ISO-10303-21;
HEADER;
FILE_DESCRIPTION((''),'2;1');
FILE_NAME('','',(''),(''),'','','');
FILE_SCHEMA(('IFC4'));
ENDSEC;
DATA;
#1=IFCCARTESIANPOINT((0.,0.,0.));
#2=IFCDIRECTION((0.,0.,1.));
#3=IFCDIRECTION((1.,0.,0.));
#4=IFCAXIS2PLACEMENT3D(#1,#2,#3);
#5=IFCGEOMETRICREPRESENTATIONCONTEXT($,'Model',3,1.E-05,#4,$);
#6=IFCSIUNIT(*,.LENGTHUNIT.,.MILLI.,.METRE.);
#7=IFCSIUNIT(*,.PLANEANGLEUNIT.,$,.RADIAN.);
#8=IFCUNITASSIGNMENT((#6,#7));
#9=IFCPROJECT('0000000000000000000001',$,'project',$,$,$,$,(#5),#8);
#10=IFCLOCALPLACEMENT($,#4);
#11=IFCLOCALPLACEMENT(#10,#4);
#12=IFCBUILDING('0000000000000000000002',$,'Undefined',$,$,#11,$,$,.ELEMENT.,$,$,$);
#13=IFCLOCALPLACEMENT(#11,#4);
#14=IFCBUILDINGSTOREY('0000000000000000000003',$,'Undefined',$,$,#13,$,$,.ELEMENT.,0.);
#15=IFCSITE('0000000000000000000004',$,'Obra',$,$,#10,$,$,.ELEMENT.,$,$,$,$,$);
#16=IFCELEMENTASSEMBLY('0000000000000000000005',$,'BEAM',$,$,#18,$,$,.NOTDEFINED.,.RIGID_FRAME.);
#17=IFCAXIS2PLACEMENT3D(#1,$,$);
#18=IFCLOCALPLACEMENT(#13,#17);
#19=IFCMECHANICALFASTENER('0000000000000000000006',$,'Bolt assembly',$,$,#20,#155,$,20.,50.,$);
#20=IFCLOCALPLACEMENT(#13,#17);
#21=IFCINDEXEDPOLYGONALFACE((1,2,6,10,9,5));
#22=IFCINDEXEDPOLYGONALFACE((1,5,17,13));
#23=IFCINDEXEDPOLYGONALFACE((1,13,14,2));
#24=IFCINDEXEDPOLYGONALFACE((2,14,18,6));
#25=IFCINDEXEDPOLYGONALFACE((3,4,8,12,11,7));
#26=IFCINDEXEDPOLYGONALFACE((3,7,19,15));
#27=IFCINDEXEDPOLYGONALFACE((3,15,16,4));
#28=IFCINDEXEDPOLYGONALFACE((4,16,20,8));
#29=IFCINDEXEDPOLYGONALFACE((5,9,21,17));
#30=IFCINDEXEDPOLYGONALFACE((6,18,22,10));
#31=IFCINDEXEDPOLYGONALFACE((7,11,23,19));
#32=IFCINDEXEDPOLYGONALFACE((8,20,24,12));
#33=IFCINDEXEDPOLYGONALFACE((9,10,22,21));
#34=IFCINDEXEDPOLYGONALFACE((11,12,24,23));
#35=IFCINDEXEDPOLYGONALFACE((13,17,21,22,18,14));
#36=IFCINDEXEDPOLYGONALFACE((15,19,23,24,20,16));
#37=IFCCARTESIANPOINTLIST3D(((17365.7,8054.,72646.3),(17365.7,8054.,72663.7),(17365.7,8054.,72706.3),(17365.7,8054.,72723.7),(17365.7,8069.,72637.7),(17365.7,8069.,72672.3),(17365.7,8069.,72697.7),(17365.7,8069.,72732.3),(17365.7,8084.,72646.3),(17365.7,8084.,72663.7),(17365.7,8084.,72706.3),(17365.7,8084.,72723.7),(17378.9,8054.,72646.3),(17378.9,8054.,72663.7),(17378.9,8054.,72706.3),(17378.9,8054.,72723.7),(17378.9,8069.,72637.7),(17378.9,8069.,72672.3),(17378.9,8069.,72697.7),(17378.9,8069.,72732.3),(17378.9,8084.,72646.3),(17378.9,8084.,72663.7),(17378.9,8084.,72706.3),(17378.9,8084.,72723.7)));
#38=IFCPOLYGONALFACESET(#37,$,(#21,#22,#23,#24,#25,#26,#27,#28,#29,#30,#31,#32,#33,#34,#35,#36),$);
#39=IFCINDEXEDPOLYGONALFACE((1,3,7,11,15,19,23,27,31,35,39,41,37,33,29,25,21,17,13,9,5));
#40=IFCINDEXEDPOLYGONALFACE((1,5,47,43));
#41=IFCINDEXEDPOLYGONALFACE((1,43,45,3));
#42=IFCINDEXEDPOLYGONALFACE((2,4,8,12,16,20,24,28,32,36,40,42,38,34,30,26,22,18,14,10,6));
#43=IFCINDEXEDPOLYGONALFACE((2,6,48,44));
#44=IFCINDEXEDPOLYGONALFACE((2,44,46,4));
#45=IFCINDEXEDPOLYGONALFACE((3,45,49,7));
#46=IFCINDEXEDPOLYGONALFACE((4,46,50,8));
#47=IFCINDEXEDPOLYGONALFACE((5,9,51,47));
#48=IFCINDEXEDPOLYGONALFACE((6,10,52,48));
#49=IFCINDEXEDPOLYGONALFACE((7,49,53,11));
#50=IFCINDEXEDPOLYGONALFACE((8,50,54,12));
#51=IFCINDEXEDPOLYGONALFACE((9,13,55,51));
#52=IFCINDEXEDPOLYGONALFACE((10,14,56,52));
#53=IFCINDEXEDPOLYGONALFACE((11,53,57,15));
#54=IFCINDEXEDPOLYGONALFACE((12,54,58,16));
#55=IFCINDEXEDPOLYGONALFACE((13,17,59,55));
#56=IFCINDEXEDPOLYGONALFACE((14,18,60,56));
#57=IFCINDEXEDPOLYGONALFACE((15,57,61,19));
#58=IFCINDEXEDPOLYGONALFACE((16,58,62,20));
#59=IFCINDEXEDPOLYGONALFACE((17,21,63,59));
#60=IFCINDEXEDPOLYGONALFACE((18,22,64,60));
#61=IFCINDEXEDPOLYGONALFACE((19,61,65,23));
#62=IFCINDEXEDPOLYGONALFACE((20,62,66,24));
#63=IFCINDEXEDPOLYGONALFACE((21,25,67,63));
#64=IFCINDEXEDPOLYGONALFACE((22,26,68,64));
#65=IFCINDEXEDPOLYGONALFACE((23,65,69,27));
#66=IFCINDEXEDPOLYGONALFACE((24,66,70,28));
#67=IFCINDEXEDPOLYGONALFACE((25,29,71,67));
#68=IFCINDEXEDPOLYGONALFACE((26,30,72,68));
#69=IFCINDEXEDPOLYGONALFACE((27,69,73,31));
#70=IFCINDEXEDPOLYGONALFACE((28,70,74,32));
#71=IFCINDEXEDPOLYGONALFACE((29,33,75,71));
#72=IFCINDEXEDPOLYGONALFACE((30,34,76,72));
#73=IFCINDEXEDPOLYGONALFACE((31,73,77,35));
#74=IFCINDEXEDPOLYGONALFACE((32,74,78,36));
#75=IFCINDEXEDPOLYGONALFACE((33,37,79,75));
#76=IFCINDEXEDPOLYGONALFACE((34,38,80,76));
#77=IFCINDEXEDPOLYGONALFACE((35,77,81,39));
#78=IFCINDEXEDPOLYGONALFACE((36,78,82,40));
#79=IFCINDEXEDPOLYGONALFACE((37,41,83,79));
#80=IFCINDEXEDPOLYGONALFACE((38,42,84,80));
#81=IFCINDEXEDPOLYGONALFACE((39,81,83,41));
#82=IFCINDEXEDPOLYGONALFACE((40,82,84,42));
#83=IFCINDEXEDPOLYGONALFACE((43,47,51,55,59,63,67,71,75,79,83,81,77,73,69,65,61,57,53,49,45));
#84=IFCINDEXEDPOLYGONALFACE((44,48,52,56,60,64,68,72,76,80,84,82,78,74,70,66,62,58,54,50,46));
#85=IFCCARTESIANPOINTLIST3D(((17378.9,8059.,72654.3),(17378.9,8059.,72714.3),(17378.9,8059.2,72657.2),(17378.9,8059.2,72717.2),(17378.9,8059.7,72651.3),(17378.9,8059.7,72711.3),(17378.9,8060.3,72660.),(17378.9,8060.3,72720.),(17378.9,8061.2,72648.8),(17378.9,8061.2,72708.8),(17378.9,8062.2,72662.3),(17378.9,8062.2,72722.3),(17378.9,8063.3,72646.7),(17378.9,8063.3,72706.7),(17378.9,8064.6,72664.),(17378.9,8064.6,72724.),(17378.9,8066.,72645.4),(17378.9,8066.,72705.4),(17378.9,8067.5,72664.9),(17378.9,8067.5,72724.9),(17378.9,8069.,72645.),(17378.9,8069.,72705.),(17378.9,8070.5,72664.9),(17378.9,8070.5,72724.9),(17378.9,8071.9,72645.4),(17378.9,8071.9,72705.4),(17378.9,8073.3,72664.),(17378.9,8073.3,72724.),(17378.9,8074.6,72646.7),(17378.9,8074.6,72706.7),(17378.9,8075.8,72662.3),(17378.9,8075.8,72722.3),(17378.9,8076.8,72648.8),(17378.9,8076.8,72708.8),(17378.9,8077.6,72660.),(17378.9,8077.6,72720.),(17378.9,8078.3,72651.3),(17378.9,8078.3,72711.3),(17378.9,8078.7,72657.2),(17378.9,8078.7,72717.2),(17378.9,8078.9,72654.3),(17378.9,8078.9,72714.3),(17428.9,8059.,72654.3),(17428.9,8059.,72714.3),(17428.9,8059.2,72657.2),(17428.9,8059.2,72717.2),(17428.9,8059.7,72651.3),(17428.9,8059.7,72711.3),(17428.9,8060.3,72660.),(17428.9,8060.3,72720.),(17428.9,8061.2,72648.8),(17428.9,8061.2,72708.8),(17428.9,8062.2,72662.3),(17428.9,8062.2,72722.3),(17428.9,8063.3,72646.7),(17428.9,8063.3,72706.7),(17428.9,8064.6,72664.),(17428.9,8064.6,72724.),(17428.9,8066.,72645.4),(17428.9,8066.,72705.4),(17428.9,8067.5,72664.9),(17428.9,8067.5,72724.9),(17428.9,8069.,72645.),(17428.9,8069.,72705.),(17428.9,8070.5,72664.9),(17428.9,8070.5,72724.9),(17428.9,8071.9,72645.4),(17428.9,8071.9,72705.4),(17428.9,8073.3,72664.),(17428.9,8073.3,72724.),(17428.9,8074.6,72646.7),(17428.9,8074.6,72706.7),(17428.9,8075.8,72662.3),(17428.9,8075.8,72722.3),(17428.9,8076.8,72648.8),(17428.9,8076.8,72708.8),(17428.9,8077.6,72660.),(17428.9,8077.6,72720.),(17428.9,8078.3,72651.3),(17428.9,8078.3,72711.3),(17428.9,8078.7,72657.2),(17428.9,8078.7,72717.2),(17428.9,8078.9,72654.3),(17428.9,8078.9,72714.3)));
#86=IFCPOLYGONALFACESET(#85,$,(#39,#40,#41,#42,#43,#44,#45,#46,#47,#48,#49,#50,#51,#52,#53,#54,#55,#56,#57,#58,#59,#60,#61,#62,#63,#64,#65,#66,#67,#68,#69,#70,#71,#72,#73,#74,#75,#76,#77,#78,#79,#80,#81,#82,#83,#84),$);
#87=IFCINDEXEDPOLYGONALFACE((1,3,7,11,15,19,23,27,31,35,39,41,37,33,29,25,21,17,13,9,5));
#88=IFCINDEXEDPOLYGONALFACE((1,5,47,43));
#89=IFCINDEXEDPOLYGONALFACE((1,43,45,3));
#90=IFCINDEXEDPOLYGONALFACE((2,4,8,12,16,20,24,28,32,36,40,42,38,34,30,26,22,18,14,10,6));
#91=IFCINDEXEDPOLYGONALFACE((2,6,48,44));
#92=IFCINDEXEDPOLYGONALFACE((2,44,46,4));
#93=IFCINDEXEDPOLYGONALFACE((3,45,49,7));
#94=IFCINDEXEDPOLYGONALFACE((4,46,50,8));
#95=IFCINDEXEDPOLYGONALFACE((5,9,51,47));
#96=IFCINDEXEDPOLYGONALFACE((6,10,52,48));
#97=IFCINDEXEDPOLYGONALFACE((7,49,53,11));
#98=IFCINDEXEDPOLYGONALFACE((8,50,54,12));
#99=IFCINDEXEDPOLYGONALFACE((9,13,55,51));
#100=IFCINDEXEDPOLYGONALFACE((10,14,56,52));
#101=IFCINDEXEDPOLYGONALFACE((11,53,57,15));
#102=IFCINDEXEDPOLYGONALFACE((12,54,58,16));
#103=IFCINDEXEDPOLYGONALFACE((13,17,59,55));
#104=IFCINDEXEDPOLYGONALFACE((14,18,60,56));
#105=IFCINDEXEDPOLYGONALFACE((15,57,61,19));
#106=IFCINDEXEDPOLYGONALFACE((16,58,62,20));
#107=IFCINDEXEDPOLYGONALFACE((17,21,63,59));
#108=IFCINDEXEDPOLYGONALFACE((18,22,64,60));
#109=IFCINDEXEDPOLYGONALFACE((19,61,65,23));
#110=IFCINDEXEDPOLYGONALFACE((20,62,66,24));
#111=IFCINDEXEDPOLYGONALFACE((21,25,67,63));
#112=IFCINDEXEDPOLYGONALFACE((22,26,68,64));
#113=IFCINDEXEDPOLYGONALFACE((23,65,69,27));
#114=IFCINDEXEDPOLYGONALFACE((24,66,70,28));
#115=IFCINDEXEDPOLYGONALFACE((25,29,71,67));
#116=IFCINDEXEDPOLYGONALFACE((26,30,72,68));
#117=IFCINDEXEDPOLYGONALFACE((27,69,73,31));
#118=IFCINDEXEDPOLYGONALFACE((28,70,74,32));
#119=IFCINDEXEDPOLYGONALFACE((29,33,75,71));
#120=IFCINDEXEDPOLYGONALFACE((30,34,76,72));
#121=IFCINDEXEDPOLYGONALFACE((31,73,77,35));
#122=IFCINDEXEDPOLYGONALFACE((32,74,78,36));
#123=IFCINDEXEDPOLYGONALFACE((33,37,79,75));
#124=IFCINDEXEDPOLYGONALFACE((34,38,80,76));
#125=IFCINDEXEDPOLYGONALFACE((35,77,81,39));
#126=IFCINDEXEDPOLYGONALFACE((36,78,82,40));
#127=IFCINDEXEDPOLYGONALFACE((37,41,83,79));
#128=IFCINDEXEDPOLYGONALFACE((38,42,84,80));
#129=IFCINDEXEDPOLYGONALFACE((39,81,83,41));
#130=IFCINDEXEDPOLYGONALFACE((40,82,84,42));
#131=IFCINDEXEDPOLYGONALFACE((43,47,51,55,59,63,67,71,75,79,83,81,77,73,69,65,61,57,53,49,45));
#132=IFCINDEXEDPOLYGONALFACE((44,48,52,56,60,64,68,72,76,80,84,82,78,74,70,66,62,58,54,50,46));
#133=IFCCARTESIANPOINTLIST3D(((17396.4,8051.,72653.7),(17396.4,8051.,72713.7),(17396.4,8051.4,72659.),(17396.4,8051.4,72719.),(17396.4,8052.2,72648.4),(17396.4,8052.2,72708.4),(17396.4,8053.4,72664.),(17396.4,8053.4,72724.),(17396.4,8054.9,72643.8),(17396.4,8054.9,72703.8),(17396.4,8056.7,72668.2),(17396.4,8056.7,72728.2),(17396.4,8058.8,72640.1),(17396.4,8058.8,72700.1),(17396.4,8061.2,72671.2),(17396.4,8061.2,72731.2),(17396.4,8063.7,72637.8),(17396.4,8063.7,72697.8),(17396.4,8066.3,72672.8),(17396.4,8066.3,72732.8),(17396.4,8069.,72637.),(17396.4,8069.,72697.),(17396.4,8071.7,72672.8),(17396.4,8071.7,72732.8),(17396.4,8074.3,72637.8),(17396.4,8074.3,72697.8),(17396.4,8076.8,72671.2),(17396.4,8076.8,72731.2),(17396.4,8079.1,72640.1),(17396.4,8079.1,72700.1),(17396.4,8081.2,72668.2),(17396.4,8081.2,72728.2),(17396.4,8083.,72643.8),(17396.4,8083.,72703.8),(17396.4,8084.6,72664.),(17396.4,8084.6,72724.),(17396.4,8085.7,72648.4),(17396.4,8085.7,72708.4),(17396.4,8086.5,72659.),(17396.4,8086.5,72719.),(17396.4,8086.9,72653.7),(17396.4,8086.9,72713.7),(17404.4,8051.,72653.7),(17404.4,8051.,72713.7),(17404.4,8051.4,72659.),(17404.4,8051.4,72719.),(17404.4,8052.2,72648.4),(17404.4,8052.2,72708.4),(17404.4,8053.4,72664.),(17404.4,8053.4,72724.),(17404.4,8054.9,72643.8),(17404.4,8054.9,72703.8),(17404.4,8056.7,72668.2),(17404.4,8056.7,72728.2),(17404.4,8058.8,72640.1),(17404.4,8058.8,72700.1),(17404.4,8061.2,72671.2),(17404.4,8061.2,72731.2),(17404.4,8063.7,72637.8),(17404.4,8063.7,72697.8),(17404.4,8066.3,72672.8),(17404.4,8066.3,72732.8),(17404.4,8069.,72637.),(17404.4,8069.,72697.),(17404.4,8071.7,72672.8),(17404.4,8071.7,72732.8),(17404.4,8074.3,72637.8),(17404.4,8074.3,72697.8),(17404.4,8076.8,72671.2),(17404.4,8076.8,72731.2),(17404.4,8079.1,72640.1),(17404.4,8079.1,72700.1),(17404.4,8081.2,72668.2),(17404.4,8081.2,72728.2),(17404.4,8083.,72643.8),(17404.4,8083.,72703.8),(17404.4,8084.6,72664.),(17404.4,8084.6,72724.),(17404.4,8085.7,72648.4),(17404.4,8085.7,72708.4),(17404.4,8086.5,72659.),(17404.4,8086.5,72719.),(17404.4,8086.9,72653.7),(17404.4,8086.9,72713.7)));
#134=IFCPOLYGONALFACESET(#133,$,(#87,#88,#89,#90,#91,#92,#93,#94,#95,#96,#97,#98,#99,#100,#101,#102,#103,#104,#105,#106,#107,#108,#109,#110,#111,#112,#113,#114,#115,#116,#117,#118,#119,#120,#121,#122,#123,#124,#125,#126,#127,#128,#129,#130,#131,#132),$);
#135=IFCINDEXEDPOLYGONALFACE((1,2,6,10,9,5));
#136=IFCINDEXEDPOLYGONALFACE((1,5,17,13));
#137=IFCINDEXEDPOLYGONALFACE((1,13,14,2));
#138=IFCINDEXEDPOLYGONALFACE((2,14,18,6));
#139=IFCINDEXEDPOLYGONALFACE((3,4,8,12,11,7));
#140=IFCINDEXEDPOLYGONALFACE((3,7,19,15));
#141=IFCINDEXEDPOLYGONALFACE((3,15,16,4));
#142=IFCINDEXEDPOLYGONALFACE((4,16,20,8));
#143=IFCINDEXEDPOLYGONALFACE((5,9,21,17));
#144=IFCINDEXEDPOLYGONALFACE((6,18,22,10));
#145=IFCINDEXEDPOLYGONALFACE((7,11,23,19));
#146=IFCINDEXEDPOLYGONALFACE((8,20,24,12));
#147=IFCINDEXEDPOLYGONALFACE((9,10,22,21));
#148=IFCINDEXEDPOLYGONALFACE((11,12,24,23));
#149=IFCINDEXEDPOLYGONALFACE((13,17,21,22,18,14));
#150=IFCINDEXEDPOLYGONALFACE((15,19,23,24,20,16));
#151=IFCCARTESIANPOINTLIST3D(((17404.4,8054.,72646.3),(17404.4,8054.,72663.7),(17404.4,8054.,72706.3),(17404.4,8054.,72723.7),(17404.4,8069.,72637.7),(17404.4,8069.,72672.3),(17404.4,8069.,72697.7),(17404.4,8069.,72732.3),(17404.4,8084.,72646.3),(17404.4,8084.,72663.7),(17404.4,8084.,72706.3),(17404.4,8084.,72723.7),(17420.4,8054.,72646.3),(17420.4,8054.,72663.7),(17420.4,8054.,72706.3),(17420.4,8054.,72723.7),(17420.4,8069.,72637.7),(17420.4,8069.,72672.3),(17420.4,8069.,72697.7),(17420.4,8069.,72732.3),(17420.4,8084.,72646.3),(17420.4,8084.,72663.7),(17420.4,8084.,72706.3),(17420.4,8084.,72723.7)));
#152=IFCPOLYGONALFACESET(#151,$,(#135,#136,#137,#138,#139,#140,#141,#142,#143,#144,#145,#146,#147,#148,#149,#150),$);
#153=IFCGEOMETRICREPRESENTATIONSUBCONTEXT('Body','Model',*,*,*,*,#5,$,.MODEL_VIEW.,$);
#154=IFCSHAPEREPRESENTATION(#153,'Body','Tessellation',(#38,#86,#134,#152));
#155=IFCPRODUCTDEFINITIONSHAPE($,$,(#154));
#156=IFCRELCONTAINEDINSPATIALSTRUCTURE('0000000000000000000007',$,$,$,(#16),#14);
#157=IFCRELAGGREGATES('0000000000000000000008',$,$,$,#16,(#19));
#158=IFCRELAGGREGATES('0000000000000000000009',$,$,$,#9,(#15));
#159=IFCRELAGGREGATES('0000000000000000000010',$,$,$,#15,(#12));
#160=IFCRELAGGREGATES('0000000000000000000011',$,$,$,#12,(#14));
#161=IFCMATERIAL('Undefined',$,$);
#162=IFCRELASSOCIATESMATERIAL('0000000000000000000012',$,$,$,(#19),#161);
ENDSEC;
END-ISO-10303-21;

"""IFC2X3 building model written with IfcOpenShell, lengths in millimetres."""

from ifc_helpers import new_model, si_unit, frame, origin_with_axes, origin_2d_with_axis, place, context, subcontext, project, spatial, polyline, circle, outline, extrude, source, transform, mapped, material, element, aggregate, save


model = new_model("IFC2X3")

# Units and contexts
model_context = context("Model", 3, precision=1e-05, world=origin_with_axes())
body_context = subcontext(model_context, "Body", "Model", "MODEL_VIEW")
ifc_project = project(units=[si_unit("LENGTHUNIT", "METRE", prefix="MILLI"), si_unit("PLANEANGLEUNIT", "RADIAN")], contexts=[model_context])

# Site, building, storey
site_placement = place(None, origin_with_axes())
site = spatial("IfcSite", under=ifc_project, at=site_placement, Name="Obra", CompositionType="ELEMENT")
building_placement = place(site_placement, origin_with_axes())
building = spatial("IfcBuilding", under=site, at=building_placement, Name="Undefined", CompositionType="ELEMENT")
storey_placement = place(building_placement, origin_with_axes())
storey = spatial("IfcBuildingStorey", under=building, at=storey_placement, Name="Undefined", CompositionType="ELEMENT", Elevation=0.0)

# Shared definitions
ifc_material = material(Name="Undefined")

# Shared definitions
shared_shape_1 = source(origin_with_axes(), body_context, "Body", "SweptSolid", [
    extrude(outline(polyline([(17.3, 0.0), (8.7, 15.0), (-8.7, 15.0), (-17.3, 0.0), (-8.7, -15.0), (8.7, -15.0), (17.3, 0.0)])), frame((0.0, -27.0, 0.0), z_axis=(0.0, 1.0, 0.0), x_axis=(1.0, 0.0, 0.0)), (0.0, 0.0, 1.0), 13.2),
    extrude(circle(Radius=10.0, at=origin_2d_with_axis()), frame((0.0, -13.8, 0.0), z_axis=(0.0, 1.0, 0.0), x_axis=(1.0, 0.0, 0.0)), (0.0, 0.0, 1.0), 50.0),
    extrude(circle(Radius=18.0, at=origin_2d_with_axis()), frame((0.0, 3.7, 0.0), z_axis=(0.0, 1.0, 0.0), x_axis=(1.0, 0.0, 0.0)), (0.0, 0.0, 1.0), 8.0),
    extrude(outline(polyline([(17.3, 0.0), (8.7, 15.0), (-8.7, 15.0), (-17.3, 0.0), (-8.7, -15.0), (8.7, -15.0), (17.3, 0.0)])), frame((0.0, 11.7, 0.0), z_axis=(0.0, 1.0, 0.0), x_axis=(1.0, 0.0, 0.0)), (0.0, 0.0, 1.0), 16.0),
])

# Element assembly, mechanical fastener
assembly_1_placement = place(storey_placement, origin_with_axes())
assembly_1 = element("IfcElementAssembly", 1, at=assembly_1_placement, inside=storey, Name="BEAM", AssemblyPlace="NOTDEFINED", PredefinedType="RIGID_FRAME")
mechanical_fastener_1_placement = place(assembly_1_placement, frame((17392.7, 8109.0, 72850.0), z_axis=(0.0, -1.0, 0.0), x_axis=(0.0, 0.0, -1.0)))
mechanical_fastener_1 = element("IfcMechanicalFastener", 2, at=mechanical_fastener_1_placement, material=ifc_material, Name="Bolt assembly", NominalDiameter=20.0, NominalLength=50.0, context=body_context, shape_type="MappedRepresentation", body=[
    mapped(shared_shape_1, transform((135.0, 0.0, 40.0))),
    mapped(shared_shape_1, transform((195.0, 0.0, 40.0))),
])

aggregate(assembly_1, [mechanical_fastener_1])

save(model, "model.ifc")
